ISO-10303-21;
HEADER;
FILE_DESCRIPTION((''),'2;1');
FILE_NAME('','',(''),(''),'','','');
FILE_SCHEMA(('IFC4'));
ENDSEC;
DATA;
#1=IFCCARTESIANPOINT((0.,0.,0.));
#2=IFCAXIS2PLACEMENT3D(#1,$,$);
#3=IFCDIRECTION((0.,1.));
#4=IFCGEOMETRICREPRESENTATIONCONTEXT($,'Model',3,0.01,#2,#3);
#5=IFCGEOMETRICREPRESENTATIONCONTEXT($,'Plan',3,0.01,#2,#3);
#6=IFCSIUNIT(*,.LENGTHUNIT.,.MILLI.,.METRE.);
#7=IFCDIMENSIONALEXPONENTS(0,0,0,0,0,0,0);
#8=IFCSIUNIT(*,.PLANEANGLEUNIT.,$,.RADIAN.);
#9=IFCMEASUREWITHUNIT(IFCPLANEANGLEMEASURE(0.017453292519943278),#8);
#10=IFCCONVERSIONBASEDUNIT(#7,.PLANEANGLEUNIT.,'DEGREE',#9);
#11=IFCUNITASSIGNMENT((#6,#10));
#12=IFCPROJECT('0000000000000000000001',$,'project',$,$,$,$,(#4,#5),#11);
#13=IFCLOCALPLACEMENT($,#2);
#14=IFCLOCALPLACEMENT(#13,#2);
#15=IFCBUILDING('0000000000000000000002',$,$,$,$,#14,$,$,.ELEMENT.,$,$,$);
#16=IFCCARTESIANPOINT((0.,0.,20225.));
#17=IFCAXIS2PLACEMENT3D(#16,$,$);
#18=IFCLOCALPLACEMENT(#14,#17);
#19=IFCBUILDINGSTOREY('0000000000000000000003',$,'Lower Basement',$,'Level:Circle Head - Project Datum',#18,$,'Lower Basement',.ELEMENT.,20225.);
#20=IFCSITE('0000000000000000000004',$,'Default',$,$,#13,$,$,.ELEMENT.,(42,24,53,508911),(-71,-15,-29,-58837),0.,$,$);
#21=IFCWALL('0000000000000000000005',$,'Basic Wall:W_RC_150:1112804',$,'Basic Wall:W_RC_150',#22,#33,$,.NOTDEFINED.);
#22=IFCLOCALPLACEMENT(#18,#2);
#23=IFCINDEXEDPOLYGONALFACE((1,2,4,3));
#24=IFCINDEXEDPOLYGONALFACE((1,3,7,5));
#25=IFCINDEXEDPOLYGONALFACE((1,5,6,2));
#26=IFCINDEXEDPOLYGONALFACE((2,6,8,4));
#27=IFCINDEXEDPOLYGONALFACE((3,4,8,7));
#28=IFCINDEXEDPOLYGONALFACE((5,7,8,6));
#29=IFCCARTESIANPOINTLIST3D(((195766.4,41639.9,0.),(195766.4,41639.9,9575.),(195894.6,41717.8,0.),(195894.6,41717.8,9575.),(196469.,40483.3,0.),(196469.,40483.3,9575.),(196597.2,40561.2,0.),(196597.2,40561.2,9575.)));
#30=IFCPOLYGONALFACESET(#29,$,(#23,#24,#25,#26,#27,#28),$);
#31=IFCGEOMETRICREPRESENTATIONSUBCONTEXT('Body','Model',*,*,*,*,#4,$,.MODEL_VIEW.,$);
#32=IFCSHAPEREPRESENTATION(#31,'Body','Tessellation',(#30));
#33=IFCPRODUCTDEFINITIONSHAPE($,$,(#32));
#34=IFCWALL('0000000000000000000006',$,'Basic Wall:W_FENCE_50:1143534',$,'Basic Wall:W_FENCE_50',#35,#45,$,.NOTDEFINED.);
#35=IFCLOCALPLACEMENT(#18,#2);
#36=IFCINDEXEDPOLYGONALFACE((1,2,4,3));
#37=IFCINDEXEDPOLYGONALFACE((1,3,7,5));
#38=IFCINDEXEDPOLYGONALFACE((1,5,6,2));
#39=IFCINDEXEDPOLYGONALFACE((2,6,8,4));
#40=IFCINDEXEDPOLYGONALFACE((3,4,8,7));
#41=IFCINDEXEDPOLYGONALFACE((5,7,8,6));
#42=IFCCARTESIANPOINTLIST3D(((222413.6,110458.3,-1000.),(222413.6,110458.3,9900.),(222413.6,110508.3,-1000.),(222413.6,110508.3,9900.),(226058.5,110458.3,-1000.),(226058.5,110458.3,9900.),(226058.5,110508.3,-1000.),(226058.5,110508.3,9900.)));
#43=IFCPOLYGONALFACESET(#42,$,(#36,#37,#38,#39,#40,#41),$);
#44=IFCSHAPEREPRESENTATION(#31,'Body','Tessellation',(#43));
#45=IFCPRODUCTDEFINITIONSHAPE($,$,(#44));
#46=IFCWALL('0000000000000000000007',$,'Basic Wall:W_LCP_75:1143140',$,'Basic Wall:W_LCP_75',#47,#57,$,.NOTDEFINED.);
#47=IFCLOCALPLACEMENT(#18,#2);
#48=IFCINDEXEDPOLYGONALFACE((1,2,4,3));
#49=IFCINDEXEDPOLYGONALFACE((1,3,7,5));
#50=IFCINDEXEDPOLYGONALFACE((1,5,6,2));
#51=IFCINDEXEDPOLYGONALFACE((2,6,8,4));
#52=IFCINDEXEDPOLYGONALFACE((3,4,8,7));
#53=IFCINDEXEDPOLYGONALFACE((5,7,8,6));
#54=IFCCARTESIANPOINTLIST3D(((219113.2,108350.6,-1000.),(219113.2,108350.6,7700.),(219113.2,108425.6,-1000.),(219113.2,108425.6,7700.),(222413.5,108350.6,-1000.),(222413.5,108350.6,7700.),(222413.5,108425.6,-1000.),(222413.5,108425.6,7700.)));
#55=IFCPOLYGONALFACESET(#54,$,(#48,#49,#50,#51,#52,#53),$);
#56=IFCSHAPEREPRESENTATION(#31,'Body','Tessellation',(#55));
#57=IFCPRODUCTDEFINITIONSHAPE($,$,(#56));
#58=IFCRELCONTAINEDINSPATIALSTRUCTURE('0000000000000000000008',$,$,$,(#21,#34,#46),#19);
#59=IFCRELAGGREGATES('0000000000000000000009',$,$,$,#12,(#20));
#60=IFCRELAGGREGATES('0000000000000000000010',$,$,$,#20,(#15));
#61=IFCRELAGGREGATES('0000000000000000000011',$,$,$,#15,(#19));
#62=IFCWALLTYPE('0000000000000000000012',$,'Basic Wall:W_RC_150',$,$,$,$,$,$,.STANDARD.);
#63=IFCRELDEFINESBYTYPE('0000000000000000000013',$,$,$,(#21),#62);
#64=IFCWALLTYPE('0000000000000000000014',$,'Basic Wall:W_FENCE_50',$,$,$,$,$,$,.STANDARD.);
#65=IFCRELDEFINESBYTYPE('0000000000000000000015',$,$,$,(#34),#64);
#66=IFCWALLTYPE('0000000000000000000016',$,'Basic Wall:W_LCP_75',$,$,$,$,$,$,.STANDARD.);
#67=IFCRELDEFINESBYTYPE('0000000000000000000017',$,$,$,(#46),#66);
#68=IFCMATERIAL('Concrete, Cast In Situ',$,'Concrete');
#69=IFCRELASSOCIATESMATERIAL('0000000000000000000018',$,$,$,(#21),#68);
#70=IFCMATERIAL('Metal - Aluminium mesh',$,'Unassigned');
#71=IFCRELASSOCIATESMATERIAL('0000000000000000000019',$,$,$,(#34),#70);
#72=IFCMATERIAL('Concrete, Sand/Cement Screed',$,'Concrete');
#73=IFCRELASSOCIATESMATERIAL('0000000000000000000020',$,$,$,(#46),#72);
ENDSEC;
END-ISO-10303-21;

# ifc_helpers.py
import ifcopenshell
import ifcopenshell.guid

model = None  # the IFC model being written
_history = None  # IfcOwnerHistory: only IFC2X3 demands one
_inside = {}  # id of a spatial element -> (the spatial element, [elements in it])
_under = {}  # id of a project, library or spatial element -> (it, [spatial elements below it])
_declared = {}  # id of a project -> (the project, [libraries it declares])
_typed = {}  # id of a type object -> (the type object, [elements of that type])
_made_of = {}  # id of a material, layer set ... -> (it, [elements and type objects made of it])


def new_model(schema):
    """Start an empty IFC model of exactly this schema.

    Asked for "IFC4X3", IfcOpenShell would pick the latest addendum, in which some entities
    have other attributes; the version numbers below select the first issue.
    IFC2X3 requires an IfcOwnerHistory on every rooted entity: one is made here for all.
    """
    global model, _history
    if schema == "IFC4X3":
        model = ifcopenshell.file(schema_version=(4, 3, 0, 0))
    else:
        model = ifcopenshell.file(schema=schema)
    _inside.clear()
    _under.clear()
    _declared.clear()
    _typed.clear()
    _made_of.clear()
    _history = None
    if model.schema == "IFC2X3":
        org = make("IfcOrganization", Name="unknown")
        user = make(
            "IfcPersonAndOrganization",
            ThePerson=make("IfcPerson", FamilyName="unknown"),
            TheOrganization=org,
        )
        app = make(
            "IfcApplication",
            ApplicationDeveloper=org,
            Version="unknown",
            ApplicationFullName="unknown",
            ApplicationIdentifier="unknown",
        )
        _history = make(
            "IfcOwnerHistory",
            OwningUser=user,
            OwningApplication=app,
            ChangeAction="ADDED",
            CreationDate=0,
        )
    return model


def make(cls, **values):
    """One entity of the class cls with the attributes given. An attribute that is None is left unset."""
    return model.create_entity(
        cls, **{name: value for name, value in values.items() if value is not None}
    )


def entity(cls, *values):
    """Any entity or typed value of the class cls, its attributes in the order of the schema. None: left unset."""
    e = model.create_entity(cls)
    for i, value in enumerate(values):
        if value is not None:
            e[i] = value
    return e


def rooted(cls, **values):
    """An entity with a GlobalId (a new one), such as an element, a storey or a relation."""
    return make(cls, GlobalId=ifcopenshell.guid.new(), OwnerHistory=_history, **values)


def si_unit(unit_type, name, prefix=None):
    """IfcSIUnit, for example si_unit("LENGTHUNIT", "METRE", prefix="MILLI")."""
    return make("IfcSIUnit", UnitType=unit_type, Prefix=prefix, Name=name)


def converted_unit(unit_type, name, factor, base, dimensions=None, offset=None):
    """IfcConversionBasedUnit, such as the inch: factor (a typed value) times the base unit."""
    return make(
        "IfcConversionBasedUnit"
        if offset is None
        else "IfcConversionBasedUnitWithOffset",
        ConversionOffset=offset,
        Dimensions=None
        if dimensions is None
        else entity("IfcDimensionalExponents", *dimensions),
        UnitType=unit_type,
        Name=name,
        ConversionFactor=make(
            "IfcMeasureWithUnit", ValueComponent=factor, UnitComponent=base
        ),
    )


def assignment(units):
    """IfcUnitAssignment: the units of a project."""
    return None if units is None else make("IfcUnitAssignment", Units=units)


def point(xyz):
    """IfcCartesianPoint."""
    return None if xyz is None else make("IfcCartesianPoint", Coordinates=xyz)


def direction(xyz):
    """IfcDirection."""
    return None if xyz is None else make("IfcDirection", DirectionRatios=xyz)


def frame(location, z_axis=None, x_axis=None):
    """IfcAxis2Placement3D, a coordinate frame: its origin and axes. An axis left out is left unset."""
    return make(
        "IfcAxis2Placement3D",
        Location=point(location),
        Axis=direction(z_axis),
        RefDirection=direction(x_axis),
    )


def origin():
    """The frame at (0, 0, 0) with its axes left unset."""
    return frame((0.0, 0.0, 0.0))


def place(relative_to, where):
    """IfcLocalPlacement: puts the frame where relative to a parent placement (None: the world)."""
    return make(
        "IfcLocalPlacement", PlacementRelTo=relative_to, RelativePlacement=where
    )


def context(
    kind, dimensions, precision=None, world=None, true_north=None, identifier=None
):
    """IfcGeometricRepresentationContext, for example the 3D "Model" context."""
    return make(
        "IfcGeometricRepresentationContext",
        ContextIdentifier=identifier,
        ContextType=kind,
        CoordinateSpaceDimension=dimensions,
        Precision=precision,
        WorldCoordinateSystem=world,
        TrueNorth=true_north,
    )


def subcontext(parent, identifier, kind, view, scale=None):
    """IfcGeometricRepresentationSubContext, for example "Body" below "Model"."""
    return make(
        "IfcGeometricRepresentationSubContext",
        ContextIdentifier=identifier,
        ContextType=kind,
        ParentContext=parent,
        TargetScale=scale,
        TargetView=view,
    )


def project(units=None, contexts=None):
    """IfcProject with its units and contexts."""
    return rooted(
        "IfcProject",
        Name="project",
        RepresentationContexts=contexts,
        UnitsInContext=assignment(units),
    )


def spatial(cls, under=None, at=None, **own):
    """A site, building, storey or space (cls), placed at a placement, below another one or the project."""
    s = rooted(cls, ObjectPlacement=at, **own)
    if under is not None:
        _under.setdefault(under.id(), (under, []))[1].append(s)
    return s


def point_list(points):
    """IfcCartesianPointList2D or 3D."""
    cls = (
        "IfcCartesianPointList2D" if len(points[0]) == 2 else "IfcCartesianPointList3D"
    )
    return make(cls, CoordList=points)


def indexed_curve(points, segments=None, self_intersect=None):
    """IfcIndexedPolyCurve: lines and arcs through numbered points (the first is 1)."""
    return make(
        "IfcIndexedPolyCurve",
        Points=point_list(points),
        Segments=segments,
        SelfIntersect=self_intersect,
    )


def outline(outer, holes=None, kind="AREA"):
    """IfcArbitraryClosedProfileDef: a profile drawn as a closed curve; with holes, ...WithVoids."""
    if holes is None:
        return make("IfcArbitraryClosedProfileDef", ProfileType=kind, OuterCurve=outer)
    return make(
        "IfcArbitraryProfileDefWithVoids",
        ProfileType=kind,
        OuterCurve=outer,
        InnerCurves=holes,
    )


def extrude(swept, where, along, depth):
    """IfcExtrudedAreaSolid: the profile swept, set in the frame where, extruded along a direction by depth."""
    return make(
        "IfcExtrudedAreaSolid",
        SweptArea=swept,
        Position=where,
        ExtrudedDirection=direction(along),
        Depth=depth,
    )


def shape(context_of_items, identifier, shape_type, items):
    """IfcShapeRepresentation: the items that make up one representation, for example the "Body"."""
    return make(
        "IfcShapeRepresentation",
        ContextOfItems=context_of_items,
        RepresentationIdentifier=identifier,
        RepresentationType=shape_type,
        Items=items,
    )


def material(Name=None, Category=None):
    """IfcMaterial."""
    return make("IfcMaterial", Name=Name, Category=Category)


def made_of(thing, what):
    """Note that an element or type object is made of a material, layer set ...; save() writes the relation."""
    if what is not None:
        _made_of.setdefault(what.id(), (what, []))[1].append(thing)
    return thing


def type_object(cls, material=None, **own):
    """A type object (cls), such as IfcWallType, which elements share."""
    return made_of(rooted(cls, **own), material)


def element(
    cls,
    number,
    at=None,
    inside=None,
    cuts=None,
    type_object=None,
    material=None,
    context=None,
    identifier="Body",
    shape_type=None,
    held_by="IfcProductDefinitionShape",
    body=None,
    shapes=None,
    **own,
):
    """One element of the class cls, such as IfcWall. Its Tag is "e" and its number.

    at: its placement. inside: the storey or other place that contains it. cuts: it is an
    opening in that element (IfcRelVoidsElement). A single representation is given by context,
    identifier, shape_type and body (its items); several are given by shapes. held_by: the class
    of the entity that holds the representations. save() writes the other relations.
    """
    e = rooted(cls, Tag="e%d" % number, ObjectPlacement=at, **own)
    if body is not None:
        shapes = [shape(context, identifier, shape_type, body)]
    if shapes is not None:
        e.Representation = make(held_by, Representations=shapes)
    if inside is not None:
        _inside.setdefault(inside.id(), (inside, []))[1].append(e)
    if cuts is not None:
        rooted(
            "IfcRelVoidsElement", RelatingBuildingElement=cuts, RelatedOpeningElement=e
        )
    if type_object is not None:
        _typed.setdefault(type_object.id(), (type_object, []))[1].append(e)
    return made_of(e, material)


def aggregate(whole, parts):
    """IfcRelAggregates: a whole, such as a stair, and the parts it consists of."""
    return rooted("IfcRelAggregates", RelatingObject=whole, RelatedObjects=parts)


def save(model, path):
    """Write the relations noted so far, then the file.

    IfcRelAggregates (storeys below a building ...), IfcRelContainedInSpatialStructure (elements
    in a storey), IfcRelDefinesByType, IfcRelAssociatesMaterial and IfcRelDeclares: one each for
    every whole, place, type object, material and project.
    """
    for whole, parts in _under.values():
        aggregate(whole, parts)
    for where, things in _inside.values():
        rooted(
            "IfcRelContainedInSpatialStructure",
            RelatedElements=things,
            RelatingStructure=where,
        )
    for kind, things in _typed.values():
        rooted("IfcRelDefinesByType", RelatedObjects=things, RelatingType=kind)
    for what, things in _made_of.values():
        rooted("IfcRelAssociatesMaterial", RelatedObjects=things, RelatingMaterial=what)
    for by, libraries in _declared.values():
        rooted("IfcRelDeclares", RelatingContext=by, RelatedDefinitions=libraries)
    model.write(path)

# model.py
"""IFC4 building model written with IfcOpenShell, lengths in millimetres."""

from ifc_helpers import new_model, entity, si_unit, converted_unit, direction, frame, origin, place, context, subcontext, project, spatial, indexed_curve, outline, extrude, material, type_object, element, save


model = new_model("IFC4")

# Units and contexts
model_context = context("Model", 3, precision=0.01, world=origin(), true_north=direction((0.0, 1.0)))
plan_context = context("Plan", 3, precision=0.01, world=origin(), true_north=direction((0.0, 1.0)))
body_context = subcontext(model_context, "Body", "Model", "MODEL_VIEW")
ifc_project = project(units=[si_unit("LENGTHUNIT", "METRE", prefix="MILLI"), converted_unit("PLANEANGLEUNIT", "DEGREE", entity("IfcPlaneAngleMeasure", 0.017453292519943278), si_unit("PLANEANGLEUNIT", "RADIAN"), dimensions=[0, 0, 0, 0, 0, 0, 0])], contexts=[model_context, plan_context])

# Site, building, storey
site_placement = place(None, origin())
site = spatial("IfcSite", under=ifc_project, at=site_placement, Name="Default", CompositionType="ELEMENT", RefLatitude=(42, 24, 53, 508911), RefLongitude=(-71, -15, -29, -58837), RefElevation=0.0)
building_placement = place(site_placement, origin())
building = spatial("IfcBuilding", under=site, at=building_placement, CompositionType="ELEMENT")
storey_placement = place(building_placement, frame((0.0, 0.0, 20225.0)))
storey = spatial("IfcBuildingStorey", under=building, at=storey_placement, Name="Lower Basement", ObjectType="Level:Circle Head - Project Datum", LongName="Lower Basement", CompositionType="ELEMENT", Elevation=20225.0)

# Walls
ifc_material_1 = material(Name="Concrete, Cast In Situ", Category="Concrete")
ifc_material_2 = material(Name="Concrete, Sand/Cement Screed", Category="Concrete")
wall_type_1 = type_object("IfcWallType", Name="Basic Wall:W_RC_150", PredefinedType="STANDARD")
wall_1_placement = place(storey_placement, frame((196533.1, 40522.2, 0.0), z_axis=(0.0, 0.0, 1.0), x_axis=(-0.519187, 0.854661, 0.0)))
element("IfcWall", 1, at=wall_1_placement, inside=storey, type_object=wall_type_1, material=ifc_material_1, Name="Basic Wall:W_RC_150:1112804", ObjectType="Basic Wall:W_RC_150", PredefinedType="NOTDEFINED", context=body_context, shape_type="SweptSolid", body=[
    extrude(outline(indexed_curve([(1353.3, -75.0), (1353.3, 75.0), (0.0, 75.0), (0.1, -75.0), (1353.3, -75.0)], self_intersect=False)), origin(), (0.0, 0.0, 1.0), 9575.0),
])
ifc_material_3 = material(Name="Metal - Aluminium mesh", Category="Unassigned")
wall_type_2 = type_object("IfcWallType", Name="Basic Wall:W_FENCE_50", PredefinedType="STANDARD")
wall_2_placement = place(storey_placement, frame((222413.6, 110483.3, -1000.0)))
element("IfcWall", 2, at=wall_2_placement, inside=storey, type_object=wall_type_2, material=ifc_material_3, Name="Basic Wall:W_FENCE_50:1143534", ObjectType="Basic Wall:W_FENCE_50", PredefinedType="NOTDEFINED", context=body_context, shape_type="SweptSolid", body=[
    extrude(outline(indexed_curve([(3644.9, 25.0), (0.0, 25.0), (0.0, -25.0), (3644.9, -25.0), (3644.9, 25.0)], self_intersect=False)), origin(), (0.0, 0.0, 1.0), 10900.0),
])
wall_type_3 = type_object("IfcWallType", Name="Basic Wall:W_LCP_75", PredefinedType="STANDARD")
wall_3_placement = place(storey_placement, frame((222413.5, 108388.1, -1000.0), z_axis=(0.0, 0.0, 1.0), x_axis=(-1.0, 0.0, 0.0)))
element("IfcWall", 3, at=wall_3_placement, inside=storey, type_object=wall_type_3, material=ifc_material_2, Name="Basic Wall:W_LCP_75:1143140", ObjectType="Basic Wall:W_LCP_75", PredefinedType="NOTDEFINED", context=body_context, shape_type="SweptSolid", body=[
    extrude(outline(indexed_curve([(3300.3, 37.5), (0.0, 37.5), (0.0, -37.5), (3300.3, -37.5), (3300.3, 37.5)], self_intersect=False)), origin(), (0.0, 0.0, 1.0), 8700.0),
])

save(model, "model.ifc")
